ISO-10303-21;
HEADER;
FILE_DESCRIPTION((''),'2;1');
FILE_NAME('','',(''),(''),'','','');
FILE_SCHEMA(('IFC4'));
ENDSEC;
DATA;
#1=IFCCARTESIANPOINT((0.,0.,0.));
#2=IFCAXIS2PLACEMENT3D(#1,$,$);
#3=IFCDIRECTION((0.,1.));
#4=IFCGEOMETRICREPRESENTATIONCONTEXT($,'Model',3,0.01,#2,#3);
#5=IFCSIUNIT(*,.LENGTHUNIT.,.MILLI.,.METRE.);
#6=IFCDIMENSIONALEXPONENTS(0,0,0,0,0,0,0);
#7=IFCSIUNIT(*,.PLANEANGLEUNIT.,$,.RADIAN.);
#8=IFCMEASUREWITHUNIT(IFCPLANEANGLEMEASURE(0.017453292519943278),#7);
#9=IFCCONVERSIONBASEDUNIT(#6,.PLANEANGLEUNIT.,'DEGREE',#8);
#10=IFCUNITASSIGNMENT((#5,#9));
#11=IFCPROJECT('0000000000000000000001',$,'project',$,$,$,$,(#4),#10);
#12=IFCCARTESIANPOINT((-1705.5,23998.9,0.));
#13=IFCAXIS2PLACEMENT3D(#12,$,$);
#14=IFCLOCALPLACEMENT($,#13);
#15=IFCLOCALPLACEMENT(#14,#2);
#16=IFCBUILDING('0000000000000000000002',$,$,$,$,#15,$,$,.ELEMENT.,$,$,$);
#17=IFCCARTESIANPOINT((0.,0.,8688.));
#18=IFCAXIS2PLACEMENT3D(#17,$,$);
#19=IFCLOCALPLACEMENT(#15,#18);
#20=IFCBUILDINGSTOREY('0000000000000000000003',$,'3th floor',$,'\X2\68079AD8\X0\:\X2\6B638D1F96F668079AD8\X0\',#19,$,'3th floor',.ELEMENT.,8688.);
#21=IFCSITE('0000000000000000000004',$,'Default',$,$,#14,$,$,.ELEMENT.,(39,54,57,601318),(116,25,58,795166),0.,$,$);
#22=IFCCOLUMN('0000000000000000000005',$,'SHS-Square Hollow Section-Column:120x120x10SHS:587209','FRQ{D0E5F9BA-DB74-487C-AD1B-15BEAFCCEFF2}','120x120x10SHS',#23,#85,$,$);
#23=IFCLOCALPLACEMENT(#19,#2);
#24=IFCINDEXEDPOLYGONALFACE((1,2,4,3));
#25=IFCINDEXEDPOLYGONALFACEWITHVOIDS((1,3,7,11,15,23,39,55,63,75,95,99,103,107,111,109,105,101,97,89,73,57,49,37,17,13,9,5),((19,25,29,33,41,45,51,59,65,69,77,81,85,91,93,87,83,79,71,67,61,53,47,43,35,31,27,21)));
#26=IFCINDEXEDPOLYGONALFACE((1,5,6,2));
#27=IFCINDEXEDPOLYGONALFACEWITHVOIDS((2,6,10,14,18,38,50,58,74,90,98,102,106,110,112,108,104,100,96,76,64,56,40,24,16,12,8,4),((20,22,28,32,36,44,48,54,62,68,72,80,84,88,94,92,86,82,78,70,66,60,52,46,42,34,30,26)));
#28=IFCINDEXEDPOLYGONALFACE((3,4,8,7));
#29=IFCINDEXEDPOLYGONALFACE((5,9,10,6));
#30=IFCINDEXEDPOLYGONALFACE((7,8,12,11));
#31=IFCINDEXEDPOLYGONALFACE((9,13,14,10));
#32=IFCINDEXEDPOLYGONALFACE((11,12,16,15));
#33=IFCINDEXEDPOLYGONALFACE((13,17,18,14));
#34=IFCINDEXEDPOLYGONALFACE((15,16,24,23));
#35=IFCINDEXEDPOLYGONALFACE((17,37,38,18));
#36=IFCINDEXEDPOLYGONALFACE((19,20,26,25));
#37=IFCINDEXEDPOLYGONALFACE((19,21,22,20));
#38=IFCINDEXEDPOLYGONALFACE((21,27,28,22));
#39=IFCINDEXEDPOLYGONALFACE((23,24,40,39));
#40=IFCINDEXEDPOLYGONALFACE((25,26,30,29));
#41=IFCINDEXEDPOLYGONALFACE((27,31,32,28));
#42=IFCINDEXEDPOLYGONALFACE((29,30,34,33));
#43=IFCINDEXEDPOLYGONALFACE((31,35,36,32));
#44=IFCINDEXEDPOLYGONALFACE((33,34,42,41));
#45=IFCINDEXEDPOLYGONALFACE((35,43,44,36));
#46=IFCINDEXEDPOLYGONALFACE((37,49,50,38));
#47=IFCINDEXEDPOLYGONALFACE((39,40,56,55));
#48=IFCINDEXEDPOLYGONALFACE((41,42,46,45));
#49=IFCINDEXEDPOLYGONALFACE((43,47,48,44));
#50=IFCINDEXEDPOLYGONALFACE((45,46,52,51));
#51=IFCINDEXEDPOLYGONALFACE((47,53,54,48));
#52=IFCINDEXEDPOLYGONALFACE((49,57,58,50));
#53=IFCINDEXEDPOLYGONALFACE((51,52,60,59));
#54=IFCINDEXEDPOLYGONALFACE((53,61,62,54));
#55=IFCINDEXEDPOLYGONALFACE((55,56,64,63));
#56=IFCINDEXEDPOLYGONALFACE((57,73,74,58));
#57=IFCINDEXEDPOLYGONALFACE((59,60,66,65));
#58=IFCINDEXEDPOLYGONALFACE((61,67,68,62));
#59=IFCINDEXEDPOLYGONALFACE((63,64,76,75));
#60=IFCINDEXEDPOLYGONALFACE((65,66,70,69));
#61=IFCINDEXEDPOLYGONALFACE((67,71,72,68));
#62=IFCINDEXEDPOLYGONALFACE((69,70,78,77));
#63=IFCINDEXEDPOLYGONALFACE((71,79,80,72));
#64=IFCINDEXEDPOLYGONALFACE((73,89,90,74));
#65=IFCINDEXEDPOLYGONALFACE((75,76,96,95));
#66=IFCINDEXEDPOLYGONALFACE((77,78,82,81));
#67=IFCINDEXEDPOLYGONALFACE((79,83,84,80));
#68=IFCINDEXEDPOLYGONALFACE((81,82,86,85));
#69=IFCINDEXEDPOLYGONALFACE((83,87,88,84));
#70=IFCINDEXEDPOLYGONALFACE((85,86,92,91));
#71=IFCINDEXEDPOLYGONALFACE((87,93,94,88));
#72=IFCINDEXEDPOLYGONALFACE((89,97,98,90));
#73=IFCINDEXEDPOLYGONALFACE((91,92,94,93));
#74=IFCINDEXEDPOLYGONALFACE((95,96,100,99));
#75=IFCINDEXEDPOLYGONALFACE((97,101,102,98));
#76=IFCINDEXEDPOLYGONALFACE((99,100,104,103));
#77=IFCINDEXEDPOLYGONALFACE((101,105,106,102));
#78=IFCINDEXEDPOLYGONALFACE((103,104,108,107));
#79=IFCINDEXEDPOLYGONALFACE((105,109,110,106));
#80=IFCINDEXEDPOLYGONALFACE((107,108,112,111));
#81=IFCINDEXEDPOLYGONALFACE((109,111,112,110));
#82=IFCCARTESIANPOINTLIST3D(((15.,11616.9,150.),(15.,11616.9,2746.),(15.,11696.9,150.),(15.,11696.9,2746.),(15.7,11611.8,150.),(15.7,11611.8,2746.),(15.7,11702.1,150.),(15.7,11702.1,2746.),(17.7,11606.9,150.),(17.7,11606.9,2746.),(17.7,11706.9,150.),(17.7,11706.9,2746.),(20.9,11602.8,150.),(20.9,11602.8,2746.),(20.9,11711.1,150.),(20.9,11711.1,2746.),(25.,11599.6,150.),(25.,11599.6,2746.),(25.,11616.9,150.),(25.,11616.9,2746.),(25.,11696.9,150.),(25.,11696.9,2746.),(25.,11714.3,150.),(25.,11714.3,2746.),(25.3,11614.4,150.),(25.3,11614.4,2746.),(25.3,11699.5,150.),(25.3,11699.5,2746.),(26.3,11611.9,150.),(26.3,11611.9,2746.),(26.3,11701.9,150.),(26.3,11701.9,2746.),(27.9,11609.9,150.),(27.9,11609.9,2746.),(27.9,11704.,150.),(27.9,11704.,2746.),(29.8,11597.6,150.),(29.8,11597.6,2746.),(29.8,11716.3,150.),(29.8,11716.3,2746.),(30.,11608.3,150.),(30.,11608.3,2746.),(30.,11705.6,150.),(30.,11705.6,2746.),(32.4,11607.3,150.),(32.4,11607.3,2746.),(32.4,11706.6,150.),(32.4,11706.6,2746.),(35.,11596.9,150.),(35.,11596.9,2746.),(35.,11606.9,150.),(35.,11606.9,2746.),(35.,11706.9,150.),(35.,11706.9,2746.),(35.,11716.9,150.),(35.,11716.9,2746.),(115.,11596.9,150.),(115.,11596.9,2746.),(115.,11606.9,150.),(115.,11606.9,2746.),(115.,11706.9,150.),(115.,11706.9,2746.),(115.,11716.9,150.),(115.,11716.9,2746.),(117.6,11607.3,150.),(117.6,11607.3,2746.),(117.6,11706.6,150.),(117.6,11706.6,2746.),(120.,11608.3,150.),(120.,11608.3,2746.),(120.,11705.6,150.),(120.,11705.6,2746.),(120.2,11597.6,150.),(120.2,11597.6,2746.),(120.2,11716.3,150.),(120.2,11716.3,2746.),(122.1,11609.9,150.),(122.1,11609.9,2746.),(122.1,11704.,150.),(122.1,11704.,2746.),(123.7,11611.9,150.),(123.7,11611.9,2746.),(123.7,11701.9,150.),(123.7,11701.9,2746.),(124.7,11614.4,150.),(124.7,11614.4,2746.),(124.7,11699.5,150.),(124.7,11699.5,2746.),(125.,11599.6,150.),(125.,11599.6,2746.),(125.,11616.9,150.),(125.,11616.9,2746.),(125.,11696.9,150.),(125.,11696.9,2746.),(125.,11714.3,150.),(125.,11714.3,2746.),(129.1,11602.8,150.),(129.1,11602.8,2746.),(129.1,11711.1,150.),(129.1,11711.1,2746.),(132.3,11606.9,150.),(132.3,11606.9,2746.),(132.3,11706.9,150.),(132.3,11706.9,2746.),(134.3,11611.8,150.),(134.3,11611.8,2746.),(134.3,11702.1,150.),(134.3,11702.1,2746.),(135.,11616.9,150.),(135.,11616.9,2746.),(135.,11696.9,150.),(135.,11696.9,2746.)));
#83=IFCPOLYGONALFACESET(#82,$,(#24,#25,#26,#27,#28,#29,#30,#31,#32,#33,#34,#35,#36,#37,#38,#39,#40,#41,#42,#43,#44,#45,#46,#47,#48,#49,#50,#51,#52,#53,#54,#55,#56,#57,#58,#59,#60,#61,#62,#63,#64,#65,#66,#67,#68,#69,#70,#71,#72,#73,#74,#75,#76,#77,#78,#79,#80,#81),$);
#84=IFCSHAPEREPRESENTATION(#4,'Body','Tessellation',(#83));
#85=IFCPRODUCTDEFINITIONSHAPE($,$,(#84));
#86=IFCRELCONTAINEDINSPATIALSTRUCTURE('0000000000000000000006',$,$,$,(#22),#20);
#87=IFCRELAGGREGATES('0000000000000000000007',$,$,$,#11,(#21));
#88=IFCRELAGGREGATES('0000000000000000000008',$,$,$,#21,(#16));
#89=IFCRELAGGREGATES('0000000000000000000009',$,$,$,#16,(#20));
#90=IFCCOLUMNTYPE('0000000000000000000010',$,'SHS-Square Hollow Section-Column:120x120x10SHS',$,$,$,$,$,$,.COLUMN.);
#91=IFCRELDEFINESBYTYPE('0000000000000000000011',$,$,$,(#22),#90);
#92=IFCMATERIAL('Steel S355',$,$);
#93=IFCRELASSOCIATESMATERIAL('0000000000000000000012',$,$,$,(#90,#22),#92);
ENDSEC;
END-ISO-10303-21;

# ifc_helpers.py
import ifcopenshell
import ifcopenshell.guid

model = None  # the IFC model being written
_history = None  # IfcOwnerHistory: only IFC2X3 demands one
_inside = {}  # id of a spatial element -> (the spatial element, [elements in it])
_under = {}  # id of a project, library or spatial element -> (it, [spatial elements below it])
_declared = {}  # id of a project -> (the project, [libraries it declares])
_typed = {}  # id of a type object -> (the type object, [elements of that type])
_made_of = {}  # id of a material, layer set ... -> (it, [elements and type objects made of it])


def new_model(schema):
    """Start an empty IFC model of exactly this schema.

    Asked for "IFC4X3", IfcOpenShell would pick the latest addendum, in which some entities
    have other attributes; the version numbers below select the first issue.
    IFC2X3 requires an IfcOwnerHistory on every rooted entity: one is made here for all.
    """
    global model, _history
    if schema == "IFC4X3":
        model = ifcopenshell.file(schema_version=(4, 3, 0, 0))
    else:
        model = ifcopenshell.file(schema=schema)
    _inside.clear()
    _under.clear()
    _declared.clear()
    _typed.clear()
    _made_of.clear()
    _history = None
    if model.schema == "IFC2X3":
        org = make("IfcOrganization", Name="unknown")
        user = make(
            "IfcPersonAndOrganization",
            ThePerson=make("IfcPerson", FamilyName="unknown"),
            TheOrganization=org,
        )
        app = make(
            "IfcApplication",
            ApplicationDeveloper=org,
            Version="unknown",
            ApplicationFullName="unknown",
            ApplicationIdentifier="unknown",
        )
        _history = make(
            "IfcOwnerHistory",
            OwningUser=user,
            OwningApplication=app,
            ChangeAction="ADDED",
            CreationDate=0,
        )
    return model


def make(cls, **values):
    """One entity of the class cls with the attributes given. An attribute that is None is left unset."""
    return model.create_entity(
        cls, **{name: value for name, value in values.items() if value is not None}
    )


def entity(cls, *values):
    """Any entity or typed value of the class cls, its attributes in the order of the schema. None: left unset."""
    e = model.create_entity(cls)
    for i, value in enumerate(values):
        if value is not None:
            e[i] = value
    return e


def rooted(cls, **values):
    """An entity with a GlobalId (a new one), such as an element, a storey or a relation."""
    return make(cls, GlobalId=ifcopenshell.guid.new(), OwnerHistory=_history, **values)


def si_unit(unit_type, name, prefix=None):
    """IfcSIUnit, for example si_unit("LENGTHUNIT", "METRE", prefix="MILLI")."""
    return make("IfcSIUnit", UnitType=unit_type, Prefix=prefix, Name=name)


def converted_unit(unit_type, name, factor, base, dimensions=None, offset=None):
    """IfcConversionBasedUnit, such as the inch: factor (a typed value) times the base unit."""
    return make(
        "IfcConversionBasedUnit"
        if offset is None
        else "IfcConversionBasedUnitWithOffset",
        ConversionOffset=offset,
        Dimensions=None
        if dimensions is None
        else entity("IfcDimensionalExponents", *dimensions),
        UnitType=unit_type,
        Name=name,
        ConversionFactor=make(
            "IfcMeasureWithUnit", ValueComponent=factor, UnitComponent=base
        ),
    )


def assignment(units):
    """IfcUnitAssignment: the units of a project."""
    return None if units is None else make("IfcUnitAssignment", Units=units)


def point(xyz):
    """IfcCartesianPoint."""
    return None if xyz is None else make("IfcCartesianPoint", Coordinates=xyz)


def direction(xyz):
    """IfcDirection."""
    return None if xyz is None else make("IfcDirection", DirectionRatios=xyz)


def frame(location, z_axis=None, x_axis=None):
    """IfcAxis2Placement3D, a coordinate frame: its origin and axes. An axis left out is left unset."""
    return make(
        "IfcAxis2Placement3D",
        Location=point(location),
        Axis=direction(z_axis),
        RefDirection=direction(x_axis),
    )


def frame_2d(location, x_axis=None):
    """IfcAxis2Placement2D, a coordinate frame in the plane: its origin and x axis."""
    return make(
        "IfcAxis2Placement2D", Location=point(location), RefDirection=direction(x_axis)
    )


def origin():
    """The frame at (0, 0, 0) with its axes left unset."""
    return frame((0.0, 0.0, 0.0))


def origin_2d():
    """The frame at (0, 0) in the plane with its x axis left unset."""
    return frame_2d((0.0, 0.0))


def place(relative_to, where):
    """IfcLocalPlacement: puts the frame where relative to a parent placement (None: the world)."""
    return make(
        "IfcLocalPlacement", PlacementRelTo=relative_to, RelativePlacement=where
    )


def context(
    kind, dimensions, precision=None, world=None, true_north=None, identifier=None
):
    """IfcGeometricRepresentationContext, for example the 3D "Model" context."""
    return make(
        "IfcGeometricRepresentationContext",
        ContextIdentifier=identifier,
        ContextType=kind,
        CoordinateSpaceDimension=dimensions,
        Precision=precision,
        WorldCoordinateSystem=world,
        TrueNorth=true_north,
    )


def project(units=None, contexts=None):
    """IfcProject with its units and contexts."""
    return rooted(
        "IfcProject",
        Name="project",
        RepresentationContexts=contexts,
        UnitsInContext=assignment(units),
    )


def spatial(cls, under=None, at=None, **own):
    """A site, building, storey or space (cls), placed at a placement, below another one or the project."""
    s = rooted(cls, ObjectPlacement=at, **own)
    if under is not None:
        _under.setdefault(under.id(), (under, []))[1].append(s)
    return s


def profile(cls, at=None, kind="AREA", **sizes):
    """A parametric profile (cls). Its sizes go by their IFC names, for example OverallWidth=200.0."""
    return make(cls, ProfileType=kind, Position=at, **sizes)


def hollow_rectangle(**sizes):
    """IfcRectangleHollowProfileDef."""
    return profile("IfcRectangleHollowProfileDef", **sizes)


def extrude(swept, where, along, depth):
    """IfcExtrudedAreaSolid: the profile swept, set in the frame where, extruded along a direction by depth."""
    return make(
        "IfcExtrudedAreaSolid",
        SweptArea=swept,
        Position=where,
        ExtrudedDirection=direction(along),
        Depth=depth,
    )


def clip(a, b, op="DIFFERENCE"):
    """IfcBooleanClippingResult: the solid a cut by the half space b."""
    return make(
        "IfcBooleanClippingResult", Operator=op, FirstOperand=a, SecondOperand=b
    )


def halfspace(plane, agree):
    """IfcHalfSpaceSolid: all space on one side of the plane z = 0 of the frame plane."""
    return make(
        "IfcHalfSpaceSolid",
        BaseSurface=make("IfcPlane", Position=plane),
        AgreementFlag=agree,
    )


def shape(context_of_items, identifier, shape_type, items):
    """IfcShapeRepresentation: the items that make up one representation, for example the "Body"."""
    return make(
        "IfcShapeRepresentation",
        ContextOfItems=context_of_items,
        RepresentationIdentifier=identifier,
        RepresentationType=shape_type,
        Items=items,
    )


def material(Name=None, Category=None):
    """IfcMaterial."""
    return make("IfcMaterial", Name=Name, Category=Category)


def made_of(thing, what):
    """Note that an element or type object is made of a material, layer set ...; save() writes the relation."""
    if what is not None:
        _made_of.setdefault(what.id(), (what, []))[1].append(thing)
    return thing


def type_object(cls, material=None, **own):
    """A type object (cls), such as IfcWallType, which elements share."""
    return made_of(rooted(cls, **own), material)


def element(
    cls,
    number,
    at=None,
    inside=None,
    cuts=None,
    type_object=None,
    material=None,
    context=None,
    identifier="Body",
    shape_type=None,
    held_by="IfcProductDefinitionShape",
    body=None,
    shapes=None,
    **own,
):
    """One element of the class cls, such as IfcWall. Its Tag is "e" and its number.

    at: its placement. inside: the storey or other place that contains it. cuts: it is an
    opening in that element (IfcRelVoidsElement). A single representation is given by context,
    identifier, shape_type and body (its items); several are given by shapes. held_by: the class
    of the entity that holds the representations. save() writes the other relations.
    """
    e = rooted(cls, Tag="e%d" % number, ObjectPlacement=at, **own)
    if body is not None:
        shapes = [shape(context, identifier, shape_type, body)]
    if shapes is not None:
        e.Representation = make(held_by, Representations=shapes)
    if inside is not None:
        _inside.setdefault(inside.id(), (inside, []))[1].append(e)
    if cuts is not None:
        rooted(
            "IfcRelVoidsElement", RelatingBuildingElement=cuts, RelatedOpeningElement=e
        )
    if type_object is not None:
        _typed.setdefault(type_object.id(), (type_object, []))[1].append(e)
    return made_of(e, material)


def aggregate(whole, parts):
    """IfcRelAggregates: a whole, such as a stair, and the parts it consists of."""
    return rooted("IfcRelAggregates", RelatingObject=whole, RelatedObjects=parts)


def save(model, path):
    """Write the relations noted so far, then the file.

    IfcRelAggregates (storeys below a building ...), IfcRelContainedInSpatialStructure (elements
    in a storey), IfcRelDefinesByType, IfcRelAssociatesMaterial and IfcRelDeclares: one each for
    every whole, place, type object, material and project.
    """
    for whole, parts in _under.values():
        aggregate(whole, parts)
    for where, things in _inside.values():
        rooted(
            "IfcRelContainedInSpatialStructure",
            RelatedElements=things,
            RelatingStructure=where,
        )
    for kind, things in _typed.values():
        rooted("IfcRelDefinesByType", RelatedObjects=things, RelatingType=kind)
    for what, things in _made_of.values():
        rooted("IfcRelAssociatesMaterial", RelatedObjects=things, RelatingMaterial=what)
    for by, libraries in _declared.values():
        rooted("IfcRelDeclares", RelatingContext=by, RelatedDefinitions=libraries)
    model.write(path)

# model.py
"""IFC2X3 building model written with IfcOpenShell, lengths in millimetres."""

from ifc_helpers import new_model, entity, si_unit, converted_unit, direction, frame, origin, origin_2d, place, context, project, spatial, hollow_rectangle, extrude, clip, halfspace, material, type_object, element, save


model = new_model("IFC2X3")

# Units and contexts
model_context = context("Model", 3, precision=0.01, world=origin(), true_north=direction((0.0, 1.0)))
ifc_project = project(units=[si_unit("LENGTHUNIT", "METRE", prefix="MILLI"), converted_unit("PLANEANGLEUNIT", "DEGREE", entity("IfcPlaneAngleMeasure", 0.017453292519943278), si_unit("PLANEANGLEUNIT", "RADIAN"), dimensions=[0, 0, 0, 0, 0, 0, 0])], contexts=[model_context])

# Site, building, storey
site_placement = place(None, frame((-1705.5, 23998.9, 0.0)))
site = spatial("IfcSite", under=ifc_project, at=site_placement, Name="Default", CompositionType="ELEMENT", RefLatitude=(39, 54, 57, 601318), RefLongitude=(116, 25, 58, 795166), RefElevation=0.0)
building_placement = place(site_placement, origin())
building = spatial("IfcBuilding", under=site, at=building_placement, CompositionType="ELEMENT")
storey_placement = place(building_placement, frame((0.0, 0.0, 8688.0)))
storey = spatial("IfcBuildingStorey", under=building, at=storey_placement, Name="3th floor", ObjectType="标高:正负零标高", LongName="3th floor", CompositionType="ELEMENT", Elevation=8688.0)

# Column
ifc_material_1 = material(Name="Steel S355")
column_type_1 = type_object("IfcColumnType", Name="SHS-Square Hollow Section-Column:120x120x10SHS", PredefinedType="COLUMN", material=ifc_material_1)
column_1_placement = place(storey_placement, frame((75.0, 11656.9, 2830.9), z_axis=(0.0, 0.0, 1.0), x_axis=(0.0, -1.0, 0.0)))
element("IfcColumn", 1, at=column_1_placement, inside=storey, type_object=column_type_1, material=ifc_material_1, Name="SHS-Square Hollow Section-Column:120x120x10SHS:587209", Description="FRQ{D0E5F9BA-DB74-487C-AD1B-15BEAFCCEFF2}", ObjectType="120x120x10SHS", context=model_context, shape_type="Clipping", body=[
    clip(clip(extrude(hollow_rectangle(XDim=120.0, YDim=120.0, WallThickness=10.0, InnerFilletRadius=10.0, OuterFilletRadius=20.0, at=origin_2d()), origin(), (0.0, 0.0, -1.0), 2765.7), halfspace(frame((11656.9, -75.0, -2680.9), z_axis=(0.0, 0.0, 1.0), x_axis=(0.0, 1.0, 0.0)), True)), halfspace(frame((11656.9, -75.0, -84.9), z_axis=(0.0, 0.0, -1.0), x_axis=(0.0, -1.0, 0.0)), True)),
])

save(model, "model.ifc")
